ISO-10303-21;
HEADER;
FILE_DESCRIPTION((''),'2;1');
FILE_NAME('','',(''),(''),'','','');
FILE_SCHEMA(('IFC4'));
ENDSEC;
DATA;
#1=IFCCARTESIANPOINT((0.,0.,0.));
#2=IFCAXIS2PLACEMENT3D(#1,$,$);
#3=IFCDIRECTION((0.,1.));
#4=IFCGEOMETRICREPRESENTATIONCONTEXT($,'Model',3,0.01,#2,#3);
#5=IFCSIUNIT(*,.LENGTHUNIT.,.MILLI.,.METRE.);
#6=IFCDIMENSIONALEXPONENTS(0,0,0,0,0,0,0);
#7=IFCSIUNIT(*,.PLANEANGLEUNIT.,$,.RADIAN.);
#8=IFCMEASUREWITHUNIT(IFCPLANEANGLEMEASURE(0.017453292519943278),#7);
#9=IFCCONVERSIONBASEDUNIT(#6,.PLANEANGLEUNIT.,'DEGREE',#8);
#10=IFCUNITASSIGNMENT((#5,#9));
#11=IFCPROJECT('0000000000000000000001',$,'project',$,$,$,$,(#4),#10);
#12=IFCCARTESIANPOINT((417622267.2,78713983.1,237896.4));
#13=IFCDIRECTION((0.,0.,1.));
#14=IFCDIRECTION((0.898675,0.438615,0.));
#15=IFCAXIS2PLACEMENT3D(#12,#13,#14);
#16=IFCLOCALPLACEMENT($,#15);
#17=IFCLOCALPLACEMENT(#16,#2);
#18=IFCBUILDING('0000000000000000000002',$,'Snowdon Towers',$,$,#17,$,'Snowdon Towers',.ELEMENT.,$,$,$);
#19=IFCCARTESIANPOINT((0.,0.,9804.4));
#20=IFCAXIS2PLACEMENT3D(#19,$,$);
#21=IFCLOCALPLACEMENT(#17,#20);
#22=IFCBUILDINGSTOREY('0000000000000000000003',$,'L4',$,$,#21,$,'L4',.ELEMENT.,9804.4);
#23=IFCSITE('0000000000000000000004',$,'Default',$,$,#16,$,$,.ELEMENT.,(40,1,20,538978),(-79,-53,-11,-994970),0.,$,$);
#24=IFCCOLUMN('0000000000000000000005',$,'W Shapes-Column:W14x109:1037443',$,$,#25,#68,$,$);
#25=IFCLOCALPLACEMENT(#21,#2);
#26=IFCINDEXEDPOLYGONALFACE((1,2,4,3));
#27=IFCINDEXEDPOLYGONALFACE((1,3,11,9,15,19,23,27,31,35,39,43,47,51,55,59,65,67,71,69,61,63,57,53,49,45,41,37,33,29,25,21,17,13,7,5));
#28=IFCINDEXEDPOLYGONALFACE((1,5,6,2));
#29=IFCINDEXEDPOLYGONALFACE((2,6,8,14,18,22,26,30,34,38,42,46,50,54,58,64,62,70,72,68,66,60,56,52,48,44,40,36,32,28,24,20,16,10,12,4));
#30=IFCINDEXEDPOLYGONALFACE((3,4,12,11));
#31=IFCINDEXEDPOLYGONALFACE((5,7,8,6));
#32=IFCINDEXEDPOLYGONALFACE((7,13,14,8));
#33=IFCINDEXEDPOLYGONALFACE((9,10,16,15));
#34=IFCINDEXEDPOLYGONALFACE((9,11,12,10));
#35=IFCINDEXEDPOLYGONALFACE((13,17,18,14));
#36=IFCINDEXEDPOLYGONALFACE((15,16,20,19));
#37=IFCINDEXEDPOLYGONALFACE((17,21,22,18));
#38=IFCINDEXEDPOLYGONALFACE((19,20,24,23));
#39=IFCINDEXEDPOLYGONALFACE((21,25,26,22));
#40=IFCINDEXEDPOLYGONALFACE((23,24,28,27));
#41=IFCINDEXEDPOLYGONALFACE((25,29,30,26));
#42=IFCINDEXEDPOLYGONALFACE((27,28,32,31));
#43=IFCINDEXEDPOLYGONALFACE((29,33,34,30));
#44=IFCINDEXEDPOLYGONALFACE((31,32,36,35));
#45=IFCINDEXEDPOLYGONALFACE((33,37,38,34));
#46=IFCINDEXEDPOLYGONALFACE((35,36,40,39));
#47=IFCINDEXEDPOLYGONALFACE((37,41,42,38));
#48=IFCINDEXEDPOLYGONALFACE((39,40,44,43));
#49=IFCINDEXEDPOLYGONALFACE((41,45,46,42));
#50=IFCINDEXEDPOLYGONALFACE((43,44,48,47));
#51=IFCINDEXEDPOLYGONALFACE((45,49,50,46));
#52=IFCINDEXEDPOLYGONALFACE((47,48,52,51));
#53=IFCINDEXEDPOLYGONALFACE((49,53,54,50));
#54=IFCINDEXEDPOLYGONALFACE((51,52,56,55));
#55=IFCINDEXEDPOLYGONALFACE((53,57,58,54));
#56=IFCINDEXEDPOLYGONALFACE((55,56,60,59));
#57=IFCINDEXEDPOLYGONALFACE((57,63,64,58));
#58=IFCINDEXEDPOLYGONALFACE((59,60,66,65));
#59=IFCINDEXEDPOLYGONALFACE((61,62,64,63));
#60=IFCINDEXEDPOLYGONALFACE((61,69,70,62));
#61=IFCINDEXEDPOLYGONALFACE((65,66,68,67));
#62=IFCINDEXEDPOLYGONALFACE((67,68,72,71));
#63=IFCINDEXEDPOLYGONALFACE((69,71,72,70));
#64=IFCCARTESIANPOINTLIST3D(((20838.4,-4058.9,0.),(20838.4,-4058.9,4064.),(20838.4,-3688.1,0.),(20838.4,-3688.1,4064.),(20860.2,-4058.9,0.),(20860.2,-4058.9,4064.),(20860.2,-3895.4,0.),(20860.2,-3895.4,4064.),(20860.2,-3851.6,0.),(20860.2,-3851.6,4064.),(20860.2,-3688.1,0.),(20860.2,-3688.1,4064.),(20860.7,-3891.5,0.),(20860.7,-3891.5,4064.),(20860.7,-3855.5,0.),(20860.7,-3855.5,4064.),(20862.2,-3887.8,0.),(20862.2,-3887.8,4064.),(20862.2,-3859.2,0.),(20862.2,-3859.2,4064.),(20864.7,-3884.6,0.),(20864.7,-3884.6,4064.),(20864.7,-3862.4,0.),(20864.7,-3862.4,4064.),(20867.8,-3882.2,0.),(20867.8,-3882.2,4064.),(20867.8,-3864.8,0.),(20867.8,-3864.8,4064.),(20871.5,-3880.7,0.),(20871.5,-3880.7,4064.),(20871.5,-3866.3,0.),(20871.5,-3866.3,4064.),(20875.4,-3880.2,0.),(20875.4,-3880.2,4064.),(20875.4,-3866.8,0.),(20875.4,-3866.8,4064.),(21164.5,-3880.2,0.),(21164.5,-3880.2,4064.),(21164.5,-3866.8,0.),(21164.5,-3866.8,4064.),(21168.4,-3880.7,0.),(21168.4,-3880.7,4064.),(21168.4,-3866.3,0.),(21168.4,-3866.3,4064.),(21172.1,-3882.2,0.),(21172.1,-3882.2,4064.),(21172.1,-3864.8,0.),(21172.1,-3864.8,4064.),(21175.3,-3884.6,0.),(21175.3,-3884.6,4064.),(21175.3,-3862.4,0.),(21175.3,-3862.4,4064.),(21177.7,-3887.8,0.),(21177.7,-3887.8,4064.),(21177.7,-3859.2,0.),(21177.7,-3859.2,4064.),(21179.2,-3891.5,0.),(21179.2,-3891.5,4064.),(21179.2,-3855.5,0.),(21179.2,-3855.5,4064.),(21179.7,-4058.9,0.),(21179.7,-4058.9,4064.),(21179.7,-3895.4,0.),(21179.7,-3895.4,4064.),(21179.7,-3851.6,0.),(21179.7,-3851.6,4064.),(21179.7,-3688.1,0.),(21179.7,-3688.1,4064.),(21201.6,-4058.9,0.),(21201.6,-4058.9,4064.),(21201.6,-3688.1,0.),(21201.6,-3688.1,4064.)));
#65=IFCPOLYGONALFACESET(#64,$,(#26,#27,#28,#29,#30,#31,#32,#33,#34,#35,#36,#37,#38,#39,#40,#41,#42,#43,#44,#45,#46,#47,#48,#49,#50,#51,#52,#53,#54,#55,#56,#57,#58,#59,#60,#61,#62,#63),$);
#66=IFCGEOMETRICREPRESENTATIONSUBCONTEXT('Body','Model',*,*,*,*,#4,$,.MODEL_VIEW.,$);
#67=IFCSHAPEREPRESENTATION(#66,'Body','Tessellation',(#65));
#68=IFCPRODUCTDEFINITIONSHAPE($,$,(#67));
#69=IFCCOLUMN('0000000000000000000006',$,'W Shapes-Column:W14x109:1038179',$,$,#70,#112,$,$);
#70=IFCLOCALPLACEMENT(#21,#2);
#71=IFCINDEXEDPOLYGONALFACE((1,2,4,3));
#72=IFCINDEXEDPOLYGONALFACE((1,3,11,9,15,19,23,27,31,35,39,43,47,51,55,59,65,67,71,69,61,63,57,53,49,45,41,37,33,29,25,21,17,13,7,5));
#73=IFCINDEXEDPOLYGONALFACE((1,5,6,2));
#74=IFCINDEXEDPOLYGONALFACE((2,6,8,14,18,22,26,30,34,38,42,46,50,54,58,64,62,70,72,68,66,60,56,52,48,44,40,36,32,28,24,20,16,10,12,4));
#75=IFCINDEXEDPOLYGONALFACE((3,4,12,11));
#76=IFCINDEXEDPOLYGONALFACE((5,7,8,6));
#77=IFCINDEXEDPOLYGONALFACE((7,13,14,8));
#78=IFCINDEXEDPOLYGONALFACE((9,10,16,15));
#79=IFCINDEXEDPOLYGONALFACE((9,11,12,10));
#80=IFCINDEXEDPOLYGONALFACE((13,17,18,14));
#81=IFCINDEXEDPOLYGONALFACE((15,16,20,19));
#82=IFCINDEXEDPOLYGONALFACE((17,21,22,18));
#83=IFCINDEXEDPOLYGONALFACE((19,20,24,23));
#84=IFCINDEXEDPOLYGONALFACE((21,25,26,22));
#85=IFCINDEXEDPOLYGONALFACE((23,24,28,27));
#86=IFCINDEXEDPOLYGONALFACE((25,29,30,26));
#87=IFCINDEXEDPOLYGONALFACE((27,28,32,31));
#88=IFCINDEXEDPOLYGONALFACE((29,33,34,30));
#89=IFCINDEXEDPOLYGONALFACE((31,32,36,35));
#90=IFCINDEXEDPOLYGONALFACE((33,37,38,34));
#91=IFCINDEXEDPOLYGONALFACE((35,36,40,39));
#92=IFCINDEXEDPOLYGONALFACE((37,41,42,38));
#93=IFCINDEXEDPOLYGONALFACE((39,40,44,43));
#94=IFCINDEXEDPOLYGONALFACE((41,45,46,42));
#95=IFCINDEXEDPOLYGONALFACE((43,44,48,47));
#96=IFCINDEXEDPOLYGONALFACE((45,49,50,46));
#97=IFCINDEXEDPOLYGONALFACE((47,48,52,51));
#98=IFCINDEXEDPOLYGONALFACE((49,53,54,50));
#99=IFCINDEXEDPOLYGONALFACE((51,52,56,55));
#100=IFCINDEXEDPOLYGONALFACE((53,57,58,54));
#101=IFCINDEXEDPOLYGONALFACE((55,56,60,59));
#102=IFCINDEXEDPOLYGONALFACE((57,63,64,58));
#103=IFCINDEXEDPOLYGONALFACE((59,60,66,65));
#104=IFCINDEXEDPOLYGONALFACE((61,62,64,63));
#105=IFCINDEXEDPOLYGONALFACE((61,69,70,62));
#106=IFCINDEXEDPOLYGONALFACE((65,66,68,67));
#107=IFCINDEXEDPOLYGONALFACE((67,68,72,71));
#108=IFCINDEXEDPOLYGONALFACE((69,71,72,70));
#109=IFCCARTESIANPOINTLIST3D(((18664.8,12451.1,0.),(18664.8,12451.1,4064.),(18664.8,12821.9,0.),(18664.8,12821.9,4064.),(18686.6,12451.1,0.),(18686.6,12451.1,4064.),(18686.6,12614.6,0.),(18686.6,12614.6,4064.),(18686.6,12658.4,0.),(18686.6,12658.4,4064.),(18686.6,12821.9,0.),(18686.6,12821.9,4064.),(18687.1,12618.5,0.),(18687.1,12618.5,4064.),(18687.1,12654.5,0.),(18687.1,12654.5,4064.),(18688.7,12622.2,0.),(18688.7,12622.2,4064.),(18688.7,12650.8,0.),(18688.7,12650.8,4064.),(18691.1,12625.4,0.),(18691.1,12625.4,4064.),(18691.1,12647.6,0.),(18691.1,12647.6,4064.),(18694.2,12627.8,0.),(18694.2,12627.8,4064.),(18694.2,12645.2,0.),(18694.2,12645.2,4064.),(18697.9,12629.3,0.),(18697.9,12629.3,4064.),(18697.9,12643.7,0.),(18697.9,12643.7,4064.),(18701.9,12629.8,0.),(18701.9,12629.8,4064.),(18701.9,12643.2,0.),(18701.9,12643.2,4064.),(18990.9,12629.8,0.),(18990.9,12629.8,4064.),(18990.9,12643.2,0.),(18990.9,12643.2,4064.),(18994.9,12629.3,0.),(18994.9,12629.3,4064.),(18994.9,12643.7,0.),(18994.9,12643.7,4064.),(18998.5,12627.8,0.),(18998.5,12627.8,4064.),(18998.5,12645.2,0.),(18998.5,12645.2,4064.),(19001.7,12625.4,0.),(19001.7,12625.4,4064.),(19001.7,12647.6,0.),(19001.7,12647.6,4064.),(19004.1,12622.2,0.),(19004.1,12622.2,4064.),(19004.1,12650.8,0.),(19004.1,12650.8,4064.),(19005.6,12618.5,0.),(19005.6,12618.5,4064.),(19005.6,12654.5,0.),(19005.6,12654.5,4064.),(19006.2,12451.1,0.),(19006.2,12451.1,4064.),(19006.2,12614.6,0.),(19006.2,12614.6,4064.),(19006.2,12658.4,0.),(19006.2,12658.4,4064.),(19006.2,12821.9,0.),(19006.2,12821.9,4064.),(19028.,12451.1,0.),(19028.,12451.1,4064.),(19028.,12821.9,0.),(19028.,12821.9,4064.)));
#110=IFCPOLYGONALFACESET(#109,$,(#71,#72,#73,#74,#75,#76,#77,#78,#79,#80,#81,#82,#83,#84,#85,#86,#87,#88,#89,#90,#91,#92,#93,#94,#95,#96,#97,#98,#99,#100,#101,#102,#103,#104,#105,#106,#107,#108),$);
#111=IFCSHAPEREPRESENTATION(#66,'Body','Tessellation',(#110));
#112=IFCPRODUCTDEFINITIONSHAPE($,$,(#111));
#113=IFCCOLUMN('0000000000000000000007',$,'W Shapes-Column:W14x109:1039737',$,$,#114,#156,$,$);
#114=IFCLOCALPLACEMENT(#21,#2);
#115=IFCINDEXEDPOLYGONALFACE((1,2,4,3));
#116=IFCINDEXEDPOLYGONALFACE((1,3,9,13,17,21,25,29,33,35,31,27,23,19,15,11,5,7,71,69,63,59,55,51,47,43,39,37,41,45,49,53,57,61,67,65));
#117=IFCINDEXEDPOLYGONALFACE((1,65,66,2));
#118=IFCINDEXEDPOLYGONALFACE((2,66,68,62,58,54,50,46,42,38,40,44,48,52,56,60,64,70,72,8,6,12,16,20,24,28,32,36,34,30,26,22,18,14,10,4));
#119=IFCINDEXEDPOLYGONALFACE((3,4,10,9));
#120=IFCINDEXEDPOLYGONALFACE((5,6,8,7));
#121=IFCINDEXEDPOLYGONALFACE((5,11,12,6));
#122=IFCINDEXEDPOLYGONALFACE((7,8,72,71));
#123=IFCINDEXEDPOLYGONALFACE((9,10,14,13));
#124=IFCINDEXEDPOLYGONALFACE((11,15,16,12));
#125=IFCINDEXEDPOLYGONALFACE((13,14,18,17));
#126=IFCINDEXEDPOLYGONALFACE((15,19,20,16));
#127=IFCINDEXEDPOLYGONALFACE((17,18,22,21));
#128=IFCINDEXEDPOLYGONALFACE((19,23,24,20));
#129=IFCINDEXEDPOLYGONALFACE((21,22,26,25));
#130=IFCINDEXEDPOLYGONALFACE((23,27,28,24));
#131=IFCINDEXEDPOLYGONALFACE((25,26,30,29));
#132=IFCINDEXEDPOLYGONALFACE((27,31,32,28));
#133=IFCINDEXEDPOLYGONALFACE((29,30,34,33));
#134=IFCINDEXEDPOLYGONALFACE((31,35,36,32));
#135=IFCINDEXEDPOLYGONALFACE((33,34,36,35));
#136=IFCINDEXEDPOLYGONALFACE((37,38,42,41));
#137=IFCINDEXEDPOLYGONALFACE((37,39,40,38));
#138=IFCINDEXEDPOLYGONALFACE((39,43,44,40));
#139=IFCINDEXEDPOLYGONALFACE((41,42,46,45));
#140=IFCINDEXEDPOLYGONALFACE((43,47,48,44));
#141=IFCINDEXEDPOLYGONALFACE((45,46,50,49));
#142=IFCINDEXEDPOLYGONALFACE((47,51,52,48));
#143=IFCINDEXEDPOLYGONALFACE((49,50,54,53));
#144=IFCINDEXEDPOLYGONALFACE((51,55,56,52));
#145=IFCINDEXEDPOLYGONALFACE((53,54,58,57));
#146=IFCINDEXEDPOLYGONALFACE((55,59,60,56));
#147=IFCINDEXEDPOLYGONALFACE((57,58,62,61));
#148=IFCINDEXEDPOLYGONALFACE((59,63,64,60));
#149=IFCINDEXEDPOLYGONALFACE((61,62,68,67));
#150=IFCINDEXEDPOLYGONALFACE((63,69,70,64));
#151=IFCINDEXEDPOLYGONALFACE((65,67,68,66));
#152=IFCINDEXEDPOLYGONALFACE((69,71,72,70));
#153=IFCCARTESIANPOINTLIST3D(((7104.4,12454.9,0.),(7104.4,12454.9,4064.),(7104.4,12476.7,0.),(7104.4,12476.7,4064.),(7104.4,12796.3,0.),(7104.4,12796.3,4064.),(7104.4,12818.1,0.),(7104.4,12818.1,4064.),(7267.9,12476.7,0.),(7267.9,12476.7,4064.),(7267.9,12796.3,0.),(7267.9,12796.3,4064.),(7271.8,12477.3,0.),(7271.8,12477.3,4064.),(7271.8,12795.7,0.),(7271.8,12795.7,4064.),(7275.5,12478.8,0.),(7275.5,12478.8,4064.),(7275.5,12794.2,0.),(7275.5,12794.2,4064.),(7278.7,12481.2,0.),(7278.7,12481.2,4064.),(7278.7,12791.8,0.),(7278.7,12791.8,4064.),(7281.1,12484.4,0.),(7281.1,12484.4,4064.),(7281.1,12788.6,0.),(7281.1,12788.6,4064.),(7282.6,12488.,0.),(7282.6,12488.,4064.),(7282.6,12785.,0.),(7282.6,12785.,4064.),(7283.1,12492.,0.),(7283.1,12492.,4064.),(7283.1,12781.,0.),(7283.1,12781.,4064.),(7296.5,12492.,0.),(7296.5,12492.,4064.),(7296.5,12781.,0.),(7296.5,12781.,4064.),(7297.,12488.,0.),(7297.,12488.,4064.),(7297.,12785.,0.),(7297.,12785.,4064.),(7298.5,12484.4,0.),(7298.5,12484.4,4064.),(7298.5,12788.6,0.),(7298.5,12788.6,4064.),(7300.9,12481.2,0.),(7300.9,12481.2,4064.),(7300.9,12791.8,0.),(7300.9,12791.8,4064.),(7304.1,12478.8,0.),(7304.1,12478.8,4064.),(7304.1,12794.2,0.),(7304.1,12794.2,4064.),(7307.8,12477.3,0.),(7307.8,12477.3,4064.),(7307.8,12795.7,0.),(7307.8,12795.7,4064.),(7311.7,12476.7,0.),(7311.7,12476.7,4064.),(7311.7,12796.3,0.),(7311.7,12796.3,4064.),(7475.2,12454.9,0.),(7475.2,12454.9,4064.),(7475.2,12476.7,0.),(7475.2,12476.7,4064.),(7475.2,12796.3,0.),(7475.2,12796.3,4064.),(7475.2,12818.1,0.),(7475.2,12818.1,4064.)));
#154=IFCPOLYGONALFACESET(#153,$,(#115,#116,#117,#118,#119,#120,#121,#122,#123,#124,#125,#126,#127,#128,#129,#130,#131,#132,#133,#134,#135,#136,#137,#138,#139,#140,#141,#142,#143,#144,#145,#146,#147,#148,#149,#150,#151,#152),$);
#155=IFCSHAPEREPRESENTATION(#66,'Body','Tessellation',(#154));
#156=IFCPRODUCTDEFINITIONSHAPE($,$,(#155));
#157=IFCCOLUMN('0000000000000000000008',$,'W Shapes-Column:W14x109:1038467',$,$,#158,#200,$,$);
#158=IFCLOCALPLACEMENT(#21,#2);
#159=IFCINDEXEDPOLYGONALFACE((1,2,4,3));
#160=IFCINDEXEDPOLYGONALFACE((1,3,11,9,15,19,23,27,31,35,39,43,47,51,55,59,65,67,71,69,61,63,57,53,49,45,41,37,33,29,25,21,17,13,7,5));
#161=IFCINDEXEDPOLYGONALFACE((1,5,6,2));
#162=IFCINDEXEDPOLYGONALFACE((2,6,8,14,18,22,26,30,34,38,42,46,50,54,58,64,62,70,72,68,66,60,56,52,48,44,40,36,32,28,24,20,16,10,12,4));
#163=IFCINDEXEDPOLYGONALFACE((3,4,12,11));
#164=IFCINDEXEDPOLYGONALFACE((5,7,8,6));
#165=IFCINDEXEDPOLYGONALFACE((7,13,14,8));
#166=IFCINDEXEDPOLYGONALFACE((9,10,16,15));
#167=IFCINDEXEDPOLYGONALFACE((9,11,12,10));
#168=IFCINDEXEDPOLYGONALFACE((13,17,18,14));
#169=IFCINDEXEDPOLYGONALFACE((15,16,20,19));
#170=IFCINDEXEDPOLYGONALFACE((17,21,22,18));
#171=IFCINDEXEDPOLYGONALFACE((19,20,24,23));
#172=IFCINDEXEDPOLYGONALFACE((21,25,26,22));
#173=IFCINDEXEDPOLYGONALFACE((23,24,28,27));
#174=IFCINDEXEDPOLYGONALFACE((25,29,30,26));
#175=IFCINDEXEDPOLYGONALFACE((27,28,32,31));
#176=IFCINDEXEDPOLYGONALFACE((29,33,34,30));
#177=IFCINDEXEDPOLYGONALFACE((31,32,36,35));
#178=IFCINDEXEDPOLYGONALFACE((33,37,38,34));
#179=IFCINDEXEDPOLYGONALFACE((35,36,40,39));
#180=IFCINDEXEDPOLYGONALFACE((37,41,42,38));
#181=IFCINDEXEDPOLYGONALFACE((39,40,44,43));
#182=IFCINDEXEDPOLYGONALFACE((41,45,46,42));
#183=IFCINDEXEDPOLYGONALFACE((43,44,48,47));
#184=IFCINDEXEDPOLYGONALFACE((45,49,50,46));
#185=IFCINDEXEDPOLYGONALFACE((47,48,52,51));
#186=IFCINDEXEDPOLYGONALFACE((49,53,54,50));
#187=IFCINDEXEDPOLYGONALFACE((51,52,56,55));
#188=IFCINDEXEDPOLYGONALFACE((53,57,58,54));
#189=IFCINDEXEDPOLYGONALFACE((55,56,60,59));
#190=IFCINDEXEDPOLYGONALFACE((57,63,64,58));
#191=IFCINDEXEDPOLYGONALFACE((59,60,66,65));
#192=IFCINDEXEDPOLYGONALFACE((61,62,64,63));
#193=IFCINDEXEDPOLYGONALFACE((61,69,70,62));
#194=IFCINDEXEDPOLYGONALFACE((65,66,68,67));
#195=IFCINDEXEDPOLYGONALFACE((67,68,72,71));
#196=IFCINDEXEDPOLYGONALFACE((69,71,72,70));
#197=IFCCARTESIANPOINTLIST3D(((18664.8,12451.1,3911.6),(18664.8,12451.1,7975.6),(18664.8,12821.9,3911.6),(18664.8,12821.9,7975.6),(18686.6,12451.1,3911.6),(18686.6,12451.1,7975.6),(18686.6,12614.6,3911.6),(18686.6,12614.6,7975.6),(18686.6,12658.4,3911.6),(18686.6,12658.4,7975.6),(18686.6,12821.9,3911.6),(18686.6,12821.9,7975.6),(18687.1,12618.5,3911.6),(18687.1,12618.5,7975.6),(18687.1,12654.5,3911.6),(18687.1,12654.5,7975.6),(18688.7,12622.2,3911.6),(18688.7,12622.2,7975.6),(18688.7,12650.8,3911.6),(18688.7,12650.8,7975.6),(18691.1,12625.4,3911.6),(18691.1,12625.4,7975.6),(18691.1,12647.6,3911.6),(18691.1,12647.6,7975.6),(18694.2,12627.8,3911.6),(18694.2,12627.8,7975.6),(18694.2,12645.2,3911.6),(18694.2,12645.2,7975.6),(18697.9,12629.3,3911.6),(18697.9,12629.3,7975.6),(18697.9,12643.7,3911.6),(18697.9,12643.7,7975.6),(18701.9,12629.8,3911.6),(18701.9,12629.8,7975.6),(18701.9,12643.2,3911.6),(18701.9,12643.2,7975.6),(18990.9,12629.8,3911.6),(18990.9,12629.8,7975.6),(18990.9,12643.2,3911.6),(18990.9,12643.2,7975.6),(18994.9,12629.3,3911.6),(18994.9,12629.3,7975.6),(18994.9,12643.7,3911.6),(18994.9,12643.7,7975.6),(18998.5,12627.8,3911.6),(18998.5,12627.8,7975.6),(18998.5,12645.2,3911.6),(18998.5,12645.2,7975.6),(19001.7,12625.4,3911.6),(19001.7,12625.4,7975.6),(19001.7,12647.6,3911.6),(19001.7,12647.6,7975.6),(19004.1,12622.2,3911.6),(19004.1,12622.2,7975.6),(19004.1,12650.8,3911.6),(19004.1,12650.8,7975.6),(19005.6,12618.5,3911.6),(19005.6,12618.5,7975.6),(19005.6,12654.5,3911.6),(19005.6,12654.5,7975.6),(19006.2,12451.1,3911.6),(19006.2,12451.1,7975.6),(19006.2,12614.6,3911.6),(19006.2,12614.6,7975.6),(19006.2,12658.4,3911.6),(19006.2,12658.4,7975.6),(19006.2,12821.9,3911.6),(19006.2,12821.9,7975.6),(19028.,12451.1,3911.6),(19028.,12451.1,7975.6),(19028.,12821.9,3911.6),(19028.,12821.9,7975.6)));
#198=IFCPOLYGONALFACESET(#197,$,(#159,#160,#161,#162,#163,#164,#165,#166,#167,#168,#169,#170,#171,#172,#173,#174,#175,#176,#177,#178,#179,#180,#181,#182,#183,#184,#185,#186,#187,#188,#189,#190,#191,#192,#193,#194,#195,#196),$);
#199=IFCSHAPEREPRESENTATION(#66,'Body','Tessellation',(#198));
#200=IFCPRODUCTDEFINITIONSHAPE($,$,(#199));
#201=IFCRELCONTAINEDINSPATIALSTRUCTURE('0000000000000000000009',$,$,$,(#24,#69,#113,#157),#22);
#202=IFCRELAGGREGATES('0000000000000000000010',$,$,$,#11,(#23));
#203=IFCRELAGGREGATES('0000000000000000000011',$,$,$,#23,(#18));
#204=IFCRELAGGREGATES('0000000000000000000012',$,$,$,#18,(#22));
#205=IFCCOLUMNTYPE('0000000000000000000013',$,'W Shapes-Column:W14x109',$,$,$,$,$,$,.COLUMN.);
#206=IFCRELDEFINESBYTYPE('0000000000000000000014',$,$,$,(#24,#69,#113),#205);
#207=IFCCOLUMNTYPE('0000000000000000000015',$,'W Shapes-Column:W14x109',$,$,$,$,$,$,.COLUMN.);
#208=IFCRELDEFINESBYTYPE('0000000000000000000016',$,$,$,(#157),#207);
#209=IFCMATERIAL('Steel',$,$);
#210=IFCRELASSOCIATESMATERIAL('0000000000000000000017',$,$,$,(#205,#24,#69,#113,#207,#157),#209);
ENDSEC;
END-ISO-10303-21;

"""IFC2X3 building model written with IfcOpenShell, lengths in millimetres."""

from ifc_helpers import new_model, entity, si_unit, converted_unit, direction, frame, frame_2d, origin, place, context, subcontext, project, spatial, i_section, extrude, source, transform, mapped, material, type_object, type_shapes, element, save


model = new_model("IFC2X3")

# Units and contexts
model_context = context("Model", 3, precision=0.01, world=origin(), true_north=direction((0.0, 1.0)))
body_context = subcontext(model_context, "Body", "Model", "MODEL_VIEW")
ifc_project = project(units=[si_unit("LENGTHUNIT", "METRE", prefix="MILLI"), converted_unit("PLANEANGLEUNIT", "DEGREE", entity("IfcPlaneAngleMeasure", 0.017453292519943278), si_unit("PLANEANGLEUNIT", "RADIAN"), dimensions=[0, 0, 0, 0, 0, 0, 0])], contexts=[model_context])

# Site, building, storey
site_placement = place(None, frame((417622267.2, 78713983.1, 237896.4), z_axis=(0.0, 0.0, 1.0), x_axis=(0.898675, 0.438615, 0.0)))
site = spatial("IfcSite", under=ifc_project, at=site_placement, Name="Default", CompositionType="ELEMENT", RefLatitude=(40, 1, 20, 538978), RefLongitude=(-79, -53, -11, -994970), RefElevation=0.0)
building_placement = place(site_placement, origin())
building = spatial("IfcBuilding", under=site, at=building_placement, Name="Snowdon Towers", LongName="Snowdon Towers", CompositionType="ELEMENT")
storey_placement = place(building_placement, frame((0.0, 0.0, 9804.4)))
storey = spatial("IfcBuildingStorey", under=building, at=storey_placement, Name="L4", LongName="L4", CompositionType="ELEMENT", Elevation=9804.4)

# Columns
ifc_material_1 = material(Name="Steel")
column_type_1 = type_object("IfcColumnType", Name="W Shapes-Column:W14x109", PredefinedType="COLUMN", material=ifc_material_1)
shared_shape_1 = source(origin(), body_context, "Body", "SweptSolid", [
    extrude(i_section(OverallWidth=370.8, OverallDepth=363.2, WebThickness=13.3, FlangeThickness=21.8, FilletRadius=15.2, at=frame_2d((0.0, 0.0), x_axis=(1.0, 0.0))), frame((0.0, 0.0, 9804.4), z_axis=(0.0, 0.0, 1.0), x_axis=(-1.0, 0.0, 0.0)), (0.0, 0.0, 1.0), 4064.0),
])
type_shapes(column_type_1, [shared_shape_1])
for number, where, z_axis, x_axis, name in (
    (1, (21020.0, -3873.5, -9804.4), (0.0, 0.0, 1.0), (0.0, 1.0, 0.0), "W Shapes-Column:W14x109:1037443"),
    (2, (18846.4, 12636.5, -9804.4), (0.0, 0.0, 1.0), (0.0, 1.0, 0.0), "W Shapes-Column:W14x109:1038179"),
):
    element("IfcColumn", number, at=place(storey_placement, frame(where, z_axis=z_axis, x_axis=x_axis)), inside=storey, type_object=column_type_1, material=ifc_material_1, Name=name, context=body_context, shape_type="MappedRepresentation", body=[
        mapped(shared_shape_1, transform((0.0, 0.0, 0.0), scale=1.0)),
    ])
column_1_placement = place(storey_placement, frame((7289.8, 12636.5, -9804.4)))
element("IfcColumn", 3, at=column_1_placement, inside=storey, type_object=column_type_1, material=ifc_material_1, Name="W Shapes-Column:W14x109:1039737", context=body_context, shape_type="MappedRepresentation", body=[
    mapped(shared_shape_1, transform((0.0, 0.0, 0.0), scale=1.0)),
])
column_type_2 = type_object("IfcColumnType", Name="W Shapes-Column:W14x109", PredefinedType="COLUMN", material=ifc_material_1)
shared_shape_2 = source(origin(), body_context, "Body", "SweptSolid", [
    extrude(i_section(OverallWidth=370.8, OverallDepth=363.2, WebThickness=13.3, FlangeThickness=21.8, FilletRadius=15.2, at=frame_2d((0.0, 0.0), x_axis=(1.0, 0.0))), frame((0.0, 0.0, 13716.0), z_axis=(0.0, 0.0, 1.0), x_axis=(-1.0, 0.0, 0.0)), (0.0, 0.0, 1.0), 4064.0),
])
type_shapes(column_type_2, [shared_shape_2])
for number, where, z_axis, x_axis, name in (
    (4, (18846.4, 12636.5, -9804.4), (0.0, 0.0, 1.0), (0.0, 1.0, 0.0), "W Shapes-Column:W14x109:1038467"),
):
    element("IfcColumn", number, at=place(storey_placement, frame(where, z_axis=z_axis, x_axis=x_axis)), inside=storey, type_object=column_type_2, material=ifc_material_1, Name=name, context=body_context, shape_type="MappedRepresentation", body=[
        mapped(shared_shape_2, transform((0.0, 0.0, 0.0), scale=1.0)),
    ])

save(model, "model.ifc")
